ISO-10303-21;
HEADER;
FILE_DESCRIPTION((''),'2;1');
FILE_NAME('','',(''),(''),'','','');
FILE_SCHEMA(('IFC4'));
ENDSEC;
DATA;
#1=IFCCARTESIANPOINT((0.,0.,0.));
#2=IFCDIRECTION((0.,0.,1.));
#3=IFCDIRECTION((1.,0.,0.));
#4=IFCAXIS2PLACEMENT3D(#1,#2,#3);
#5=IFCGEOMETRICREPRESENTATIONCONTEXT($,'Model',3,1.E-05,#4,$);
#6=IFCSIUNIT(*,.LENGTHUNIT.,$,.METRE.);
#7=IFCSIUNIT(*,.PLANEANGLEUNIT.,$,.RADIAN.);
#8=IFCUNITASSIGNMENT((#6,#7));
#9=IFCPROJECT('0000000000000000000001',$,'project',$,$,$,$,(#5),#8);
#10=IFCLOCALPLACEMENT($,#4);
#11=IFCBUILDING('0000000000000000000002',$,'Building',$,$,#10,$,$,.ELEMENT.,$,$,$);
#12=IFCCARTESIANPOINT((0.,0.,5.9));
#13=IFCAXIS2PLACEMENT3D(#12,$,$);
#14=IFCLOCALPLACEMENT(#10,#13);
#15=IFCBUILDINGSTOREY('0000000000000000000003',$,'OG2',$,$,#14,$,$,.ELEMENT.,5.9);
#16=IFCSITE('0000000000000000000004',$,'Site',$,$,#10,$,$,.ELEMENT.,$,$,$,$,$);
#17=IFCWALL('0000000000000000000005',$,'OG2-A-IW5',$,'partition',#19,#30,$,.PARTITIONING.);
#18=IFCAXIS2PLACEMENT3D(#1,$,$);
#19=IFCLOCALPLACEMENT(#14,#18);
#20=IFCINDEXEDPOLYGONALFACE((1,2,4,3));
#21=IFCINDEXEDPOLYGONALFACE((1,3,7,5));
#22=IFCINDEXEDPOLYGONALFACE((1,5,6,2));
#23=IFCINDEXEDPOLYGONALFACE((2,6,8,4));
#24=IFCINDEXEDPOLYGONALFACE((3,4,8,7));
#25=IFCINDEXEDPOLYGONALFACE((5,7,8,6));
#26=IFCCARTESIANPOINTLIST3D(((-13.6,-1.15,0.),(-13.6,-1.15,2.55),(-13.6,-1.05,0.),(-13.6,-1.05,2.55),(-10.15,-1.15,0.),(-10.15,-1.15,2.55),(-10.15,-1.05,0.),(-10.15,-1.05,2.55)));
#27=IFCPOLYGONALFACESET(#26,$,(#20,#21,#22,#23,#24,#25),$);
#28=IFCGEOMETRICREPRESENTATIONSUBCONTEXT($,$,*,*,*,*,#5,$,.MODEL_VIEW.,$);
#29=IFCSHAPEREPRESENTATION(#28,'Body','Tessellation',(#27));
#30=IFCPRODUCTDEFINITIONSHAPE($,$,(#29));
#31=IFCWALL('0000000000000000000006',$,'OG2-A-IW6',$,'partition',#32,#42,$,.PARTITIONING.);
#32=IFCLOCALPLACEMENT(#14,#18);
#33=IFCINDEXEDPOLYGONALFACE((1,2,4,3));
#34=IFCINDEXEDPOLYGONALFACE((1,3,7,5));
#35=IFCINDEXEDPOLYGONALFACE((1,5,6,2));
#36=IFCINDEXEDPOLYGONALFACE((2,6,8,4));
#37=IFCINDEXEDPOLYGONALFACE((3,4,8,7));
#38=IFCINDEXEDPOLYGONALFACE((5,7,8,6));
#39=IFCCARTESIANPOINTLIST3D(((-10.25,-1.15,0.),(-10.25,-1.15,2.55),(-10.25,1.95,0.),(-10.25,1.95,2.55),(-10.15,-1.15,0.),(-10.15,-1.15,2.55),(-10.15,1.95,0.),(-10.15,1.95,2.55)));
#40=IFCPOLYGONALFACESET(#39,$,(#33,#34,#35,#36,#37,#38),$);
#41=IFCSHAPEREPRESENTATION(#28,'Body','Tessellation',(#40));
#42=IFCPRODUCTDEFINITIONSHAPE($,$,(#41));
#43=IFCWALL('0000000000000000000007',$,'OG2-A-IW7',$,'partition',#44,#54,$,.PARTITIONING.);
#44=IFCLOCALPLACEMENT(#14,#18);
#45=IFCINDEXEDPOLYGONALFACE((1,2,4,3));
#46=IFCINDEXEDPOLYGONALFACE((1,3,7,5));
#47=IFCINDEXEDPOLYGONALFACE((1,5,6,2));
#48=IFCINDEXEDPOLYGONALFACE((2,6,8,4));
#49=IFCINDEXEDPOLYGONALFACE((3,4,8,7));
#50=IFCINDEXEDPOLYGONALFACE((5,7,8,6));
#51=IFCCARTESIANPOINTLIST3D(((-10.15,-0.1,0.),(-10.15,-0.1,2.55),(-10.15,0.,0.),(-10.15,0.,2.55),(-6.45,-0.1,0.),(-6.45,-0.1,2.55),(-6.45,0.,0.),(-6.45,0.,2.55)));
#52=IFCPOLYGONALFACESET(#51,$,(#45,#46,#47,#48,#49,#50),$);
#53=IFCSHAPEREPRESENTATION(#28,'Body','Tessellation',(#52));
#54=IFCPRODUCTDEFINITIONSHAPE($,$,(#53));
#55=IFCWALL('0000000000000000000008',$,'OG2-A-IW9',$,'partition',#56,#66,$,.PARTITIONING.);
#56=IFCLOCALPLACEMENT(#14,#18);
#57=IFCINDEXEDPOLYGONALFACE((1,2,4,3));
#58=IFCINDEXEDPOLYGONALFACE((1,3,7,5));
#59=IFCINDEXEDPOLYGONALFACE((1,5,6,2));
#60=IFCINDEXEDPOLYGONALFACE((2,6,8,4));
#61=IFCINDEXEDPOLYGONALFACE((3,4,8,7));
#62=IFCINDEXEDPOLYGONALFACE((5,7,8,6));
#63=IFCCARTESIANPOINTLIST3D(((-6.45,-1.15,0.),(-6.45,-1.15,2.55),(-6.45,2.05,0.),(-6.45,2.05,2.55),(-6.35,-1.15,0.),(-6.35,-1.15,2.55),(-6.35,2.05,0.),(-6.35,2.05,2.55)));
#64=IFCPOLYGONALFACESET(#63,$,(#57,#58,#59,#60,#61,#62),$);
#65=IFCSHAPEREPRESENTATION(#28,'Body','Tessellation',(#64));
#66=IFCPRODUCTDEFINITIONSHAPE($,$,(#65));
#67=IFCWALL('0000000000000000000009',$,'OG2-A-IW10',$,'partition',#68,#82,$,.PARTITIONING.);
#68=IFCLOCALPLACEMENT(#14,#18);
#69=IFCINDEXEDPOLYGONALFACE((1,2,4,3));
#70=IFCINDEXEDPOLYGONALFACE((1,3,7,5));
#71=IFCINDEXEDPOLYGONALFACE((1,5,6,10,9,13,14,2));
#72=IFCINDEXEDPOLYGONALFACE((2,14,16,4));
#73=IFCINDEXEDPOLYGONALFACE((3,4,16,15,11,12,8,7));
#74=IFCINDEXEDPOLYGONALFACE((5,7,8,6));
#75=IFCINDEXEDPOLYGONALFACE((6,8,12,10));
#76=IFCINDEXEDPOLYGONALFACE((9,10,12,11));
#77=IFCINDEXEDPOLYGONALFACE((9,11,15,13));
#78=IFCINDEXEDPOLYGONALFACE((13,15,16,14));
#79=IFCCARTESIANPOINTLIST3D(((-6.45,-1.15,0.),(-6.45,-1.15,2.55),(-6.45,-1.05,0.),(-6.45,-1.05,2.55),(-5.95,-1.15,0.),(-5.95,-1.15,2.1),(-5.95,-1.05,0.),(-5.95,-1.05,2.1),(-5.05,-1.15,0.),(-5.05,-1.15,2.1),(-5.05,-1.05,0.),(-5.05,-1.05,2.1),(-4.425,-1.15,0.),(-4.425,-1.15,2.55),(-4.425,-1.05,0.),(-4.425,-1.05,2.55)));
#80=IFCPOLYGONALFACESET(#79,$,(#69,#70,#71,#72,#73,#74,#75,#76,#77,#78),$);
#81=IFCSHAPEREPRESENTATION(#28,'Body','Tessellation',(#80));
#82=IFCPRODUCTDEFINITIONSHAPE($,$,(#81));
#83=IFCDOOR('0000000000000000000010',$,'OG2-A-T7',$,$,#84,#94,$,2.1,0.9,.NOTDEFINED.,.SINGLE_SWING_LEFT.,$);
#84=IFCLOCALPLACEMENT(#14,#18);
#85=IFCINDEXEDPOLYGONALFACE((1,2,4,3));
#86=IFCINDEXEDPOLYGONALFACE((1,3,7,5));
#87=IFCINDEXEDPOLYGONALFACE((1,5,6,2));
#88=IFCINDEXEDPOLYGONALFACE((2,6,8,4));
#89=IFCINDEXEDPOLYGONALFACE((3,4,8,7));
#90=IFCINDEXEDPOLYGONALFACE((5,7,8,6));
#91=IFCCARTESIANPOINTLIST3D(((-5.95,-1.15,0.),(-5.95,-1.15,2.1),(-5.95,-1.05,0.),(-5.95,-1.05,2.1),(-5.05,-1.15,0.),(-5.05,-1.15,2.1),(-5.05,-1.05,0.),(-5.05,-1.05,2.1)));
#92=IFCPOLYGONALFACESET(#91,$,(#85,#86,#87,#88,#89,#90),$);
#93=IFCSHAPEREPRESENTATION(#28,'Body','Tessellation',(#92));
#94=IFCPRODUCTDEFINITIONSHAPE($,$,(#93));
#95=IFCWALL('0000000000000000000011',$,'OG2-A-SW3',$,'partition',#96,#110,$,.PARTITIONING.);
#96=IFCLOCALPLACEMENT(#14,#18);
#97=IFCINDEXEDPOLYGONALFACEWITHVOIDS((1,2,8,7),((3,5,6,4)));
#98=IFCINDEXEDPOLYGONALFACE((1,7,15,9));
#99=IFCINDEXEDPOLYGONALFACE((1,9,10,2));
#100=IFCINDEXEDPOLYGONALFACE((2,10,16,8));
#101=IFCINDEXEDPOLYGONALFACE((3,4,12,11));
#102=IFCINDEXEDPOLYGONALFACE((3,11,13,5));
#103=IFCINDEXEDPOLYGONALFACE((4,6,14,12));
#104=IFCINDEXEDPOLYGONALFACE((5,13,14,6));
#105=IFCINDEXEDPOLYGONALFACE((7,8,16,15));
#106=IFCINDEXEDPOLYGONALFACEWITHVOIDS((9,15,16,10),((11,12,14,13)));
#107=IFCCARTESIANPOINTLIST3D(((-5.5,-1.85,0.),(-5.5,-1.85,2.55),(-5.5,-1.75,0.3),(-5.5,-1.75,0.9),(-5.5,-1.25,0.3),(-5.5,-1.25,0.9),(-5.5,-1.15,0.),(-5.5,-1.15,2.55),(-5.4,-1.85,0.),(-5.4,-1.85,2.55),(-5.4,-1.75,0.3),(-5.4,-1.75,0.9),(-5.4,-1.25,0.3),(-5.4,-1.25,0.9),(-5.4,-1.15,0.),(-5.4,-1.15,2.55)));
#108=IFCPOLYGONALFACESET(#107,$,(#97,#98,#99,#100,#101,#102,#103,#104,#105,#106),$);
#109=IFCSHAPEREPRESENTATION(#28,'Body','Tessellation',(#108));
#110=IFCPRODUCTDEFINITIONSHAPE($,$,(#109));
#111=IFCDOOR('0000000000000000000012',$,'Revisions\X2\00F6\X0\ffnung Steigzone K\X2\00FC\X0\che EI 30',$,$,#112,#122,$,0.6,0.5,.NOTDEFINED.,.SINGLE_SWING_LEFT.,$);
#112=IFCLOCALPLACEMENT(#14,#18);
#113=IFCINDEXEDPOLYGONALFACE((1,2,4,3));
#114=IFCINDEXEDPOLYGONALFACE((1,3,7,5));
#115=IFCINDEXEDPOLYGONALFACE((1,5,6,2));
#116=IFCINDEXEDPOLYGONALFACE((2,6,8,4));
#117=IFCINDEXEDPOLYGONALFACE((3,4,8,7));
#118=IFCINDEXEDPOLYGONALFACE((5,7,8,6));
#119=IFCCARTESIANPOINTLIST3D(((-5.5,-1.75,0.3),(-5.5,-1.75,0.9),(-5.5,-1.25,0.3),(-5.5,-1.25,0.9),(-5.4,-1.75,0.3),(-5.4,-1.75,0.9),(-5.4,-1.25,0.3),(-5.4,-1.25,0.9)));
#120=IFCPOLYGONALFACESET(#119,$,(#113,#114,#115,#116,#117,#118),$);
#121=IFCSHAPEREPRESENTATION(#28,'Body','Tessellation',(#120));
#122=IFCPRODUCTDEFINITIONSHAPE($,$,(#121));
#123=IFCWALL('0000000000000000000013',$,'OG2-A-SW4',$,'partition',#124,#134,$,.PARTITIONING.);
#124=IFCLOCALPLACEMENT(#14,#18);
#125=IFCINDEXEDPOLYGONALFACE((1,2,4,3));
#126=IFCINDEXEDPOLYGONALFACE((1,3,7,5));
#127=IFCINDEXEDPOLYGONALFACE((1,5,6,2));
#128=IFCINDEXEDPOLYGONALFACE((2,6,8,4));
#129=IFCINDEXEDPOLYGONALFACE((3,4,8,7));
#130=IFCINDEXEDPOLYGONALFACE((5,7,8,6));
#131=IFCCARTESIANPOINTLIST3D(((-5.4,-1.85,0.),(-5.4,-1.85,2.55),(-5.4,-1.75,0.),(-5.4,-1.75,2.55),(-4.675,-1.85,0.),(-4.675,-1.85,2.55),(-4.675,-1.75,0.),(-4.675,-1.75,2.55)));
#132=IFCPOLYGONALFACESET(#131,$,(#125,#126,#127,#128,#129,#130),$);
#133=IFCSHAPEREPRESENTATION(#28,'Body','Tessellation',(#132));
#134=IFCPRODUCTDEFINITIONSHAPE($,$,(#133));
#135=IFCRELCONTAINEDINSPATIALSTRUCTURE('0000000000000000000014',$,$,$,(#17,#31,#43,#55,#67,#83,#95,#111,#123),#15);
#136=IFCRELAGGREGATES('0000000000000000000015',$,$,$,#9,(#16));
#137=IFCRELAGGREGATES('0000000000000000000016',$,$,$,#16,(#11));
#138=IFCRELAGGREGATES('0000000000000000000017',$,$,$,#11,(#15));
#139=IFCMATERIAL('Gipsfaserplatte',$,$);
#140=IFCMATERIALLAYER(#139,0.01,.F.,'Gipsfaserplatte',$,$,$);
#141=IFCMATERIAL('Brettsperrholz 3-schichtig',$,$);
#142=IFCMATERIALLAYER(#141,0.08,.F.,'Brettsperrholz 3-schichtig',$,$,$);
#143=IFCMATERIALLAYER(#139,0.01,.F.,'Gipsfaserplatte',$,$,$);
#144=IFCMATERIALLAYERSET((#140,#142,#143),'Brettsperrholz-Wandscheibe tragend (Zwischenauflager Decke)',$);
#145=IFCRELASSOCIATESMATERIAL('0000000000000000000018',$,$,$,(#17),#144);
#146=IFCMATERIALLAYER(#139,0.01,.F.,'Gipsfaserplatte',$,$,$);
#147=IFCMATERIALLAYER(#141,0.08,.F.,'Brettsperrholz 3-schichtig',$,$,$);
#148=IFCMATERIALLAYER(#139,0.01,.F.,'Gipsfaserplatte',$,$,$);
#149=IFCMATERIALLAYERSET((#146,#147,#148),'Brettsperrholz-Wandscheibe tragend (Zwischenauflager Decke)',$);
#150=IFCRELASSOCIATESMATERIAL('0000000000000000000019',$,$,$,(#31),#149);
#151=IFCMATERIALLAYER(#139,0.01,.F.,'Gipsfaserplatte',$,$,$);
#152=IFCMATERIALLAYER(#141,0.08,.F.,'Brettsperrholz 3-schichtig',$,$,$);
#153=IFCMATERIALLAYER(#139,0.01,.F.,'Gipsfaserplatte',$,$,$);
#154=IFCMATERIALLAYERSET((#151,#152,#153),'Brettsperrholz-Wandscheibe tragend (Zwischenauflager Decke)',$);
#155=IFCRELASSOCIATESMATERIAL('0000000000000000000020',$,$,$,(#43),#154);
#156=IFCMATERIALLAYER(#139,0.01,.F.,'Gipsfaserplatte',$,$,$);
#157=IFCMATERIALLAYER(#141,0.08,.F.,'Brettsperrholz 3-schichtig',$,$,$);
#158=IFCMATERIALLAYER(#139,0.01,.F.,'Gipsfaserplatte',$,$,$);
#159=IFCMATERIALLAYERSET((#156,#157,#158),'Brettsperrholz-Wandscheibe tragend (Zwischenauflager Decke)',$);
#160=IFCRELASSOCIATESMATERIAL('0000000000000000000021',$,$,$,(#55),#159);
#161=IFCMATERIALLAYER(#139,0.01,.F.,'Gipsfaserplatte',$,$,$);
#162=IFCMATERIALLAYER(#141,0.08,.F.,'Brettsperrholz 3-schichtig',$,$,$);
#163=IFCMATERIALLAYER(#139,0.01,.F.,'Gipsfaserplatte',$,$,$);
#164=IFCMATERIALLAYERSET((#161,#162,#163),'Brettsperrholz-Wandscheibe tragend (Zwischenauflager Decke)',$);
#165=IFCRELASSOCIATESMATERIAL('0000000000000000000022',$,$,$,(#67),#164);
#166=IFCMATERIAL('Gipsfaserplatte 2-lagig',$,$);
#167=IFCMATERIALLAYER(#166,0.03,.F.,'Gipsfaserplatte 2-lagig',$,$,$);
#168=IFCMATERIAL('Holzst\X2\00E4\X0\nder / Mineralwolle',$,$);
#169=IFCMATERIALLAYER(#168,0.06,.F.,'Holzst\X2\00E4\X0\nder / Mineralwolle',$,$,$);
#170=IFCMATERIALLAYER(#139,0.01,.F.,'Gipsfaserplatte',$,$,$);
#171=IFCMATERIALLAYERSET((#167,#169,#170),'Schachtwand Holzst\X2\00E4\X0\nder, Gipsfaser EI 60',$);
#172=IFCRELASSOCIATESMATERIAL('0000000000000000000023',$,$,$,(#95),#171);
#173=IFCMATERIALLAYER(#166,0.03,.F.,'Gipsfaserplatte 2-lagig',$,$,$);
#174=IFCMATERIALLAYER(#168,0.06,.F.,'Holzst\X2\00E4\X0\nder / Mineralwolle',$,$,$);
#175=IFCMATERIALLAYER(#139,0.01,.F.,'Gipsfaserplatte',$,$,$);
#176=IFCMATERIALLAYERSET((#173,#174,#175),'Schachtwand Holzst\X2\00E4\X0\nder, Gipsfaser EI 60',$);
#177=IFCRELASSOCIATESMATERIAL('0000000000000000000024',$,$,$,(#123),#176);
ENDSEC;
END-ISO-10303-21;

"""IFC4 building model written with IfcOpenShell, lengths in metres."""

from ifc_helpers import new_model, si_unit, frame, frame_2d, origin, origin_with_axes, place, context, subcontext, project, spatial, rectangle, extrude, material, layer, layer_set, element, fill, save


model = new_model("IFC4")

# Units and contexts
model_context = context("Model", 3, precision=1e-05, world=origin_with_axes())
sub_context = subcontext(model_context, None, None, "MODEL_VIEW")
ifc_project = project(units=[si_unit("LENGTHUNIT", "METRE"), si_unit("PLANEANGLEUNIT", "RADIAN")], contexts=[model_context])

# Site, building, storey
placement = place(None, origin_with_axes())
site = spatial("IfcSite", under=ifc_project, at=placement, Name="Site", CompositionType="ELEMENT")
building = spatial("IfcBuilding", under=site, at=placement, Name="Building", CompositionType="ELEMENT")
storey_placement = place(placement, frame((0.0, 0.0, 5.9)))
storey = spatial("IfcBuildingStorey", under=building, at=storey_placement, Name="OG2", CompositionType="ELEMENT", Elevation=5.9)

# Shared definitions
ifc_material_1 = material(Name="Gipsfaserplatte")

# Walls
ifc_layer_1 = layer(ifc_material_1, 0.01, ventilated=False, Name="Gipsfaserplatte")
ifc_material_2 = material(Name="Brettsperrholz 3-schichtig")
ifc_layer_2 = layer(ifc_material_2, 0.08, ventilated=False, Name="Brettsperrholz 3-schichtig")
ifc_layer_3 = layer(ifc_material_1, 0.01, ventilated=False, Name="Gipsfaserplatte")
ifc_layer_set_1 = layer_set([ifc_layer_1, ifc_layer_2, ifc_layer_3], Name="Brettsperrholz-Wandscheibe tragend (Zwischenauflager Decke)")
wall_1_placement = place(storey_placement, frame((-13.6, -1.1, 0.0), z_axis=(0.0, 0.0, 1.0), x_axis=(1.0, 0.0, 0.0)))
element("IfcWall", 1, at=wall_1_placement, inside=storey, material=ifc_layer_set_1, Name="OG2-A-IW5", ObjectType="partition", PredefinedType="PARTITIONING", context=sub_context, shape_type="SweptSolid", body=[
    extrude(rectangle(XDim=3.45, YDim=0.1, at=frame_2d((1.725, 0.0))), origin(), (0.0, 0.0, 1.0), 2.55),
])
ifc_layer_4 = layer(ifc_material_1, 0.01, ventilated=False, Name="Gipsfaserplatte")
ifc_layer_5 = layer(ifc_material_2, 0.08, ventilated=False, Name="Brettsperrholz 3-schichtig")
ifc_layer_6 = layer(ifc_material_1, 0.01, ventilated=False, Name="Gipsfaserplatte")
ifc_layer_set_2 = layer_set([ifc_layer_4, ifc_layer_5, ifc_layer_6], Name="Brettsperrholz-Wandscheibe tragend (Zwischenauflager Decke)")
wall_2_placement = place(storey_placement, frame((-10.2, -1.15, 0.0), z_axis=(0.0, 0.0, 1.0), x_axis=(0.0, 1.0, 0.0)))
element("IfcWall", 2, at=wall_2_placement, inside=storey, material=ifc_layer_set_2, Name="OG2-A-IW6", ObjectType="partition", PredefinedType="PARTITIONING", context=sub_context, shape_type="SweptSolid", body=[
    extrude(rectangle(XDim=3.1, YDim=0.1, at=frame_2d((1.55, 0.0))), origin(), (0.0, 0.0, 1.0), 2.55),
])
ifc_layer_7 = layer(ifc_material_1, 0.01, ventilated=False, Name="Gipsfaserplatte")
ifc_layer_8 = layer(ifc_material_2, 0.08, ventilated=False, Name="Brettsperrholz 3-schichtig")
ifc_layer_9 = layer(ifc_material_1, 0.01, ventilated=False, Name="Gipsfaserplatte")
ifc_layer_set_3 = layer_set([ifc_layer_7, ifc_layer_8, ifc_layer_9], Name="Brettsperrholz-Wandscheibe tragend (Zwischenauflager Decke)")
wall_3_placement = place(storey_placement, frame((-10.15, -0.05, 0.0), z_axis=(0.0, 0.0, 1.0), x_axis=(1.0, 0.0, 0.0)))
element("IfcWall", 3, at=wall_3_placement, inside=storey, material=ifc_layer_set_3, Name="OG2-A-IW7", ObjectType="partition", PredefinedType="PARTITIONING", context=sub_context, shape_type="SweptSolid", body=[
    extrude(rectangle(XDim=3.7, YDim=0.1, at=frame_2d((1.85, 0.0))), origin(), (0.0, 0.0, 1.0), 2.55),
])
ifc_layer_10 = layer(ifc_material_1, 0.01, ventilated=False, Name="Gipsfaserplatte")
ifc_layer_11 = layer(ifc_material_2, 0.08, ventilated=False, Name="Brettsperrholz 3-schichtig")
ifc_layer_12 = layer(ifc_material_1, 0.01, ventilated=False, Name="Gipsfaserplatte")
ifc_layer_set_4 = layer_set([ifc_layer_10, ifc_layer_11, ifc_layer_12], Name="Brettsperrholz-Wandscheibe tragend (Zwischenauflager Decke)")
wall_4_placement = place(storey_placement, frame((-6.4, -1.15, 0.0), z_axis=(0.0, 0.0, 1.0), x_axis=(0.0, 1.0, 0.0)))
element("IfcWall", 4, at=wall_4_placement, inside=storey, material=ifc_layer_set_4, Name="OG2-A-IW9", ObjectType="partition", PredefinedType="PARTITIONING", context=sub_context, shape_type="SweptSolid", body=[
    extrude(rectangle(XDim=3.2, YDim=0.1, at=frame_2d((1.6, 0.0))), origin(), (0.0, 0.0, 1.0), 2.55),
])

# Walls, openings, doors
ifc_layer_13 = layer(ifc_material_1, 0.01, ventilated=False, Name="Gipsfaserplatte")
ifc_layer_14 = layer(ifc_material_2, 0.08, ventilated=False, Name="Brettsperrholz 3-schichtig")
ifc_layer_15 = layer(ifc_material_1, 0.01, ventilated=False, Name="Gipsfaserplatte")
ifc_layer_set_5 = layer_set([ifc_layer_13, ifc_layer_14, ifc_layer_15], Name="Brettsperrholz-Wandscheibe tragend (Zwischenauflager Decke)")
wall_5_placement = place(storey_placement, frame((-6.45, -1.1, 0.0), z_axis=(0.0, 0.0, 1.0), x_axis=(1.0, 0.0, 0.0)))
wall_5 = element("IfcWall", 5, at=wall_5_placement, inside=storey, material=ifc_layer_set_5, Name="OG2-A-IW10", ObjectType="partition", PredefinedType="PARTITIONING", context=sub_context, shape_type="SweptSolid", body=[
    extrude(rectangle(XDim=2.025, YDim=0.1, at=frame_2d((1.0125, 0.0))), origin(), (0.0, 0.0, 1.0), 2.55),
])
opening_1_placement = place(wall_5_placement, frame((0.95, 0.1, 0.0), z_axis=(0.0, -1.0, 0.0), x_axis=(1.0, 0.0, 0.0)))
opening_1 = element("IfcOpeningElement", 6, at=opening_1_placement, cuts=wall_5, PredefinedType="OPENING", context=sub_context, shape_type="SweptSolid", body=[
    extrude(rectangle(XDim=0.9, YDim=2.1, at=frame_2d((0.0, 1.05))), origin(), (0.0, 0.0, 1.0), 0.2),
])
door_1_placement = place(wall_5_placement, frame((0.95, 0.05, 0.0), z_axis=(0.0, -1.0, 0.0), x_axis=(1.0, 0.0, 0.0)))
door_1 = element("IfcDoor", 7, at=door_1_placement, inside=storey, Name="OG2-A-T7", OperationType="SINGLE_SWING_LEFT", OverallHeight=2.1, OverallWidth=0.9, PredefinedType="NOTDEFINED", context=sub_context, shape_type="SweptSolid", body=[
    extrude(rectangle(XDim=0.9, YDim=2.1, at=frame_2d((0.0, 1.05))), origin(), (0.0, 0.0, 1.0), 0.1),
])
fill(opening_1, door_1)
ifc_material_3 = material(Name="Gipsfaserplatte 2-lagig")
ifc_layer_16 = layer(ifc_material_3, 0.03, ventilated=False, Name="Gipsfaserplatte 2-lagig")
ifc_material_4 = material(Name="Holzständer / Mineralwolle")
ifc_layer_17 = layer(ifc_material_4, 0.06, ventilated=False, Name="Holzständer / Mineralwolle")
ifc_layer_18 = layer(ifc_material_1, 0.01, ventilated=False, Name="Gipsfaserplatte")
ifc_layer_set_6 = layer_set([ifc_layer_16, ifc_layer_17, ifc_layer_18], Name="Schachtwand Holzständer, Gipsfaser EI 60")
wall_6_placement = place(storey_placement, frame((-5.45, -1.85, 0.0), z_axis=(0.0, 0.0, 1.0), x_axis=(0.0, 1.0, 0.0)))
wall_6 = element("IfcWall", 8, at=wall_6_placement, inside=storey, material=ifc_layer_set_6, Name="OG2-A-SW3", ObjectType="partition", PredefinedType="PARTITIONING", context=sub_context, shape_type="SweptSolid", body=[
    extrude(rectangle(XDim=0.7, YDim=0.1, at=frame_2d((0.35, 0.0))), origin(), (0.0, 0.0, 1.0), 2.55),
])
opening_2_placement = place(wall_6_placement, frame((0.35, 0.1, 0.3), z_axis=(0.0, -1.0, 0.0), x_axis=(1.0, 0.0, 0.0)))
opening_2 = element("IfcOpeningElement", 9, at=opening_2_placement, cuts=wall_6, PredefinedType="OPENING", context=sub_context, shape_type="SweptSolid", body=[
    extrude(rectangle(XDim=0.5, YDim=0.6, at=frame_2d((0.0, 0.3))), origin(), (0.0, 0.0, 1.0), 0.2),
])
door_2_placement = place(wall_6_placement, frame((0.35, 0.05, 0.3), z_axis=(0.0, -1.0, 0.0), x_axis=(1.0, 0.0, 0.0)))
door_2 = element("IfcDoor", 10, at=door_2_placement, inside=storey, Name="Revisionsöffnung Steigzone Küche EI 30", OperationType="SINGLE_SWING_LEFT", OverallHeight=0.6, OverallWidth=0.5, PredefinedType="NOTDEFINED", context=sub_context, shape_type="SweptSolid", body=[
    extrude(rectangle(XDim=0.5, YDim=0.6, at=frame_2d((0.0, 0.3))), origin(), (0.0, 0.0, 1.0), 0.1),
])
fill(opening_2, door_2)

# Wall
ifc_layer_19 = layer(ifc_material_3, 0.03, ventilated=False, Name="Gipsfaserplatte 2-lagig")
ifc_layer_20 = layer(ifc_material_4, 0.06, ventilated=False, Name="Holzständer / Mineralwolle")
ifc_layer_21 = layer(ifc_material_1, 0.01, ventilated=False, Name="Gipsfaserplatte")
ifc_layer_set_7 = layer_set([ifc_layer_19, ifc_layer_20, ifc_layer_21], Name="Schachtwand Holzständer, Gipsfaser EI 60")
wall_7_placement = place(storey_placement, frame((-5.4, -1.8, 0.0), z_axis=(0.0, 0.0, 1.0), x_axis=(1.0, 0.0, 0.0)))
element("IfcWall", 11, at=wall_7_placement, inside=storey, material=ifc_layer_set_7, Name="OG2-A-SW4", ObjectType="partition", PredefinedType="PARTITIONING", context=sub_context, shape_type="SweptSolid", body=[
    extrude(rectangle(XDim=0.725, YDim=0.1, at=frame_2d((0.3625, 0.0))), origin(), (0.0, 0.0, 1.0), 2.55),
])

save(model, "model.ifc")
